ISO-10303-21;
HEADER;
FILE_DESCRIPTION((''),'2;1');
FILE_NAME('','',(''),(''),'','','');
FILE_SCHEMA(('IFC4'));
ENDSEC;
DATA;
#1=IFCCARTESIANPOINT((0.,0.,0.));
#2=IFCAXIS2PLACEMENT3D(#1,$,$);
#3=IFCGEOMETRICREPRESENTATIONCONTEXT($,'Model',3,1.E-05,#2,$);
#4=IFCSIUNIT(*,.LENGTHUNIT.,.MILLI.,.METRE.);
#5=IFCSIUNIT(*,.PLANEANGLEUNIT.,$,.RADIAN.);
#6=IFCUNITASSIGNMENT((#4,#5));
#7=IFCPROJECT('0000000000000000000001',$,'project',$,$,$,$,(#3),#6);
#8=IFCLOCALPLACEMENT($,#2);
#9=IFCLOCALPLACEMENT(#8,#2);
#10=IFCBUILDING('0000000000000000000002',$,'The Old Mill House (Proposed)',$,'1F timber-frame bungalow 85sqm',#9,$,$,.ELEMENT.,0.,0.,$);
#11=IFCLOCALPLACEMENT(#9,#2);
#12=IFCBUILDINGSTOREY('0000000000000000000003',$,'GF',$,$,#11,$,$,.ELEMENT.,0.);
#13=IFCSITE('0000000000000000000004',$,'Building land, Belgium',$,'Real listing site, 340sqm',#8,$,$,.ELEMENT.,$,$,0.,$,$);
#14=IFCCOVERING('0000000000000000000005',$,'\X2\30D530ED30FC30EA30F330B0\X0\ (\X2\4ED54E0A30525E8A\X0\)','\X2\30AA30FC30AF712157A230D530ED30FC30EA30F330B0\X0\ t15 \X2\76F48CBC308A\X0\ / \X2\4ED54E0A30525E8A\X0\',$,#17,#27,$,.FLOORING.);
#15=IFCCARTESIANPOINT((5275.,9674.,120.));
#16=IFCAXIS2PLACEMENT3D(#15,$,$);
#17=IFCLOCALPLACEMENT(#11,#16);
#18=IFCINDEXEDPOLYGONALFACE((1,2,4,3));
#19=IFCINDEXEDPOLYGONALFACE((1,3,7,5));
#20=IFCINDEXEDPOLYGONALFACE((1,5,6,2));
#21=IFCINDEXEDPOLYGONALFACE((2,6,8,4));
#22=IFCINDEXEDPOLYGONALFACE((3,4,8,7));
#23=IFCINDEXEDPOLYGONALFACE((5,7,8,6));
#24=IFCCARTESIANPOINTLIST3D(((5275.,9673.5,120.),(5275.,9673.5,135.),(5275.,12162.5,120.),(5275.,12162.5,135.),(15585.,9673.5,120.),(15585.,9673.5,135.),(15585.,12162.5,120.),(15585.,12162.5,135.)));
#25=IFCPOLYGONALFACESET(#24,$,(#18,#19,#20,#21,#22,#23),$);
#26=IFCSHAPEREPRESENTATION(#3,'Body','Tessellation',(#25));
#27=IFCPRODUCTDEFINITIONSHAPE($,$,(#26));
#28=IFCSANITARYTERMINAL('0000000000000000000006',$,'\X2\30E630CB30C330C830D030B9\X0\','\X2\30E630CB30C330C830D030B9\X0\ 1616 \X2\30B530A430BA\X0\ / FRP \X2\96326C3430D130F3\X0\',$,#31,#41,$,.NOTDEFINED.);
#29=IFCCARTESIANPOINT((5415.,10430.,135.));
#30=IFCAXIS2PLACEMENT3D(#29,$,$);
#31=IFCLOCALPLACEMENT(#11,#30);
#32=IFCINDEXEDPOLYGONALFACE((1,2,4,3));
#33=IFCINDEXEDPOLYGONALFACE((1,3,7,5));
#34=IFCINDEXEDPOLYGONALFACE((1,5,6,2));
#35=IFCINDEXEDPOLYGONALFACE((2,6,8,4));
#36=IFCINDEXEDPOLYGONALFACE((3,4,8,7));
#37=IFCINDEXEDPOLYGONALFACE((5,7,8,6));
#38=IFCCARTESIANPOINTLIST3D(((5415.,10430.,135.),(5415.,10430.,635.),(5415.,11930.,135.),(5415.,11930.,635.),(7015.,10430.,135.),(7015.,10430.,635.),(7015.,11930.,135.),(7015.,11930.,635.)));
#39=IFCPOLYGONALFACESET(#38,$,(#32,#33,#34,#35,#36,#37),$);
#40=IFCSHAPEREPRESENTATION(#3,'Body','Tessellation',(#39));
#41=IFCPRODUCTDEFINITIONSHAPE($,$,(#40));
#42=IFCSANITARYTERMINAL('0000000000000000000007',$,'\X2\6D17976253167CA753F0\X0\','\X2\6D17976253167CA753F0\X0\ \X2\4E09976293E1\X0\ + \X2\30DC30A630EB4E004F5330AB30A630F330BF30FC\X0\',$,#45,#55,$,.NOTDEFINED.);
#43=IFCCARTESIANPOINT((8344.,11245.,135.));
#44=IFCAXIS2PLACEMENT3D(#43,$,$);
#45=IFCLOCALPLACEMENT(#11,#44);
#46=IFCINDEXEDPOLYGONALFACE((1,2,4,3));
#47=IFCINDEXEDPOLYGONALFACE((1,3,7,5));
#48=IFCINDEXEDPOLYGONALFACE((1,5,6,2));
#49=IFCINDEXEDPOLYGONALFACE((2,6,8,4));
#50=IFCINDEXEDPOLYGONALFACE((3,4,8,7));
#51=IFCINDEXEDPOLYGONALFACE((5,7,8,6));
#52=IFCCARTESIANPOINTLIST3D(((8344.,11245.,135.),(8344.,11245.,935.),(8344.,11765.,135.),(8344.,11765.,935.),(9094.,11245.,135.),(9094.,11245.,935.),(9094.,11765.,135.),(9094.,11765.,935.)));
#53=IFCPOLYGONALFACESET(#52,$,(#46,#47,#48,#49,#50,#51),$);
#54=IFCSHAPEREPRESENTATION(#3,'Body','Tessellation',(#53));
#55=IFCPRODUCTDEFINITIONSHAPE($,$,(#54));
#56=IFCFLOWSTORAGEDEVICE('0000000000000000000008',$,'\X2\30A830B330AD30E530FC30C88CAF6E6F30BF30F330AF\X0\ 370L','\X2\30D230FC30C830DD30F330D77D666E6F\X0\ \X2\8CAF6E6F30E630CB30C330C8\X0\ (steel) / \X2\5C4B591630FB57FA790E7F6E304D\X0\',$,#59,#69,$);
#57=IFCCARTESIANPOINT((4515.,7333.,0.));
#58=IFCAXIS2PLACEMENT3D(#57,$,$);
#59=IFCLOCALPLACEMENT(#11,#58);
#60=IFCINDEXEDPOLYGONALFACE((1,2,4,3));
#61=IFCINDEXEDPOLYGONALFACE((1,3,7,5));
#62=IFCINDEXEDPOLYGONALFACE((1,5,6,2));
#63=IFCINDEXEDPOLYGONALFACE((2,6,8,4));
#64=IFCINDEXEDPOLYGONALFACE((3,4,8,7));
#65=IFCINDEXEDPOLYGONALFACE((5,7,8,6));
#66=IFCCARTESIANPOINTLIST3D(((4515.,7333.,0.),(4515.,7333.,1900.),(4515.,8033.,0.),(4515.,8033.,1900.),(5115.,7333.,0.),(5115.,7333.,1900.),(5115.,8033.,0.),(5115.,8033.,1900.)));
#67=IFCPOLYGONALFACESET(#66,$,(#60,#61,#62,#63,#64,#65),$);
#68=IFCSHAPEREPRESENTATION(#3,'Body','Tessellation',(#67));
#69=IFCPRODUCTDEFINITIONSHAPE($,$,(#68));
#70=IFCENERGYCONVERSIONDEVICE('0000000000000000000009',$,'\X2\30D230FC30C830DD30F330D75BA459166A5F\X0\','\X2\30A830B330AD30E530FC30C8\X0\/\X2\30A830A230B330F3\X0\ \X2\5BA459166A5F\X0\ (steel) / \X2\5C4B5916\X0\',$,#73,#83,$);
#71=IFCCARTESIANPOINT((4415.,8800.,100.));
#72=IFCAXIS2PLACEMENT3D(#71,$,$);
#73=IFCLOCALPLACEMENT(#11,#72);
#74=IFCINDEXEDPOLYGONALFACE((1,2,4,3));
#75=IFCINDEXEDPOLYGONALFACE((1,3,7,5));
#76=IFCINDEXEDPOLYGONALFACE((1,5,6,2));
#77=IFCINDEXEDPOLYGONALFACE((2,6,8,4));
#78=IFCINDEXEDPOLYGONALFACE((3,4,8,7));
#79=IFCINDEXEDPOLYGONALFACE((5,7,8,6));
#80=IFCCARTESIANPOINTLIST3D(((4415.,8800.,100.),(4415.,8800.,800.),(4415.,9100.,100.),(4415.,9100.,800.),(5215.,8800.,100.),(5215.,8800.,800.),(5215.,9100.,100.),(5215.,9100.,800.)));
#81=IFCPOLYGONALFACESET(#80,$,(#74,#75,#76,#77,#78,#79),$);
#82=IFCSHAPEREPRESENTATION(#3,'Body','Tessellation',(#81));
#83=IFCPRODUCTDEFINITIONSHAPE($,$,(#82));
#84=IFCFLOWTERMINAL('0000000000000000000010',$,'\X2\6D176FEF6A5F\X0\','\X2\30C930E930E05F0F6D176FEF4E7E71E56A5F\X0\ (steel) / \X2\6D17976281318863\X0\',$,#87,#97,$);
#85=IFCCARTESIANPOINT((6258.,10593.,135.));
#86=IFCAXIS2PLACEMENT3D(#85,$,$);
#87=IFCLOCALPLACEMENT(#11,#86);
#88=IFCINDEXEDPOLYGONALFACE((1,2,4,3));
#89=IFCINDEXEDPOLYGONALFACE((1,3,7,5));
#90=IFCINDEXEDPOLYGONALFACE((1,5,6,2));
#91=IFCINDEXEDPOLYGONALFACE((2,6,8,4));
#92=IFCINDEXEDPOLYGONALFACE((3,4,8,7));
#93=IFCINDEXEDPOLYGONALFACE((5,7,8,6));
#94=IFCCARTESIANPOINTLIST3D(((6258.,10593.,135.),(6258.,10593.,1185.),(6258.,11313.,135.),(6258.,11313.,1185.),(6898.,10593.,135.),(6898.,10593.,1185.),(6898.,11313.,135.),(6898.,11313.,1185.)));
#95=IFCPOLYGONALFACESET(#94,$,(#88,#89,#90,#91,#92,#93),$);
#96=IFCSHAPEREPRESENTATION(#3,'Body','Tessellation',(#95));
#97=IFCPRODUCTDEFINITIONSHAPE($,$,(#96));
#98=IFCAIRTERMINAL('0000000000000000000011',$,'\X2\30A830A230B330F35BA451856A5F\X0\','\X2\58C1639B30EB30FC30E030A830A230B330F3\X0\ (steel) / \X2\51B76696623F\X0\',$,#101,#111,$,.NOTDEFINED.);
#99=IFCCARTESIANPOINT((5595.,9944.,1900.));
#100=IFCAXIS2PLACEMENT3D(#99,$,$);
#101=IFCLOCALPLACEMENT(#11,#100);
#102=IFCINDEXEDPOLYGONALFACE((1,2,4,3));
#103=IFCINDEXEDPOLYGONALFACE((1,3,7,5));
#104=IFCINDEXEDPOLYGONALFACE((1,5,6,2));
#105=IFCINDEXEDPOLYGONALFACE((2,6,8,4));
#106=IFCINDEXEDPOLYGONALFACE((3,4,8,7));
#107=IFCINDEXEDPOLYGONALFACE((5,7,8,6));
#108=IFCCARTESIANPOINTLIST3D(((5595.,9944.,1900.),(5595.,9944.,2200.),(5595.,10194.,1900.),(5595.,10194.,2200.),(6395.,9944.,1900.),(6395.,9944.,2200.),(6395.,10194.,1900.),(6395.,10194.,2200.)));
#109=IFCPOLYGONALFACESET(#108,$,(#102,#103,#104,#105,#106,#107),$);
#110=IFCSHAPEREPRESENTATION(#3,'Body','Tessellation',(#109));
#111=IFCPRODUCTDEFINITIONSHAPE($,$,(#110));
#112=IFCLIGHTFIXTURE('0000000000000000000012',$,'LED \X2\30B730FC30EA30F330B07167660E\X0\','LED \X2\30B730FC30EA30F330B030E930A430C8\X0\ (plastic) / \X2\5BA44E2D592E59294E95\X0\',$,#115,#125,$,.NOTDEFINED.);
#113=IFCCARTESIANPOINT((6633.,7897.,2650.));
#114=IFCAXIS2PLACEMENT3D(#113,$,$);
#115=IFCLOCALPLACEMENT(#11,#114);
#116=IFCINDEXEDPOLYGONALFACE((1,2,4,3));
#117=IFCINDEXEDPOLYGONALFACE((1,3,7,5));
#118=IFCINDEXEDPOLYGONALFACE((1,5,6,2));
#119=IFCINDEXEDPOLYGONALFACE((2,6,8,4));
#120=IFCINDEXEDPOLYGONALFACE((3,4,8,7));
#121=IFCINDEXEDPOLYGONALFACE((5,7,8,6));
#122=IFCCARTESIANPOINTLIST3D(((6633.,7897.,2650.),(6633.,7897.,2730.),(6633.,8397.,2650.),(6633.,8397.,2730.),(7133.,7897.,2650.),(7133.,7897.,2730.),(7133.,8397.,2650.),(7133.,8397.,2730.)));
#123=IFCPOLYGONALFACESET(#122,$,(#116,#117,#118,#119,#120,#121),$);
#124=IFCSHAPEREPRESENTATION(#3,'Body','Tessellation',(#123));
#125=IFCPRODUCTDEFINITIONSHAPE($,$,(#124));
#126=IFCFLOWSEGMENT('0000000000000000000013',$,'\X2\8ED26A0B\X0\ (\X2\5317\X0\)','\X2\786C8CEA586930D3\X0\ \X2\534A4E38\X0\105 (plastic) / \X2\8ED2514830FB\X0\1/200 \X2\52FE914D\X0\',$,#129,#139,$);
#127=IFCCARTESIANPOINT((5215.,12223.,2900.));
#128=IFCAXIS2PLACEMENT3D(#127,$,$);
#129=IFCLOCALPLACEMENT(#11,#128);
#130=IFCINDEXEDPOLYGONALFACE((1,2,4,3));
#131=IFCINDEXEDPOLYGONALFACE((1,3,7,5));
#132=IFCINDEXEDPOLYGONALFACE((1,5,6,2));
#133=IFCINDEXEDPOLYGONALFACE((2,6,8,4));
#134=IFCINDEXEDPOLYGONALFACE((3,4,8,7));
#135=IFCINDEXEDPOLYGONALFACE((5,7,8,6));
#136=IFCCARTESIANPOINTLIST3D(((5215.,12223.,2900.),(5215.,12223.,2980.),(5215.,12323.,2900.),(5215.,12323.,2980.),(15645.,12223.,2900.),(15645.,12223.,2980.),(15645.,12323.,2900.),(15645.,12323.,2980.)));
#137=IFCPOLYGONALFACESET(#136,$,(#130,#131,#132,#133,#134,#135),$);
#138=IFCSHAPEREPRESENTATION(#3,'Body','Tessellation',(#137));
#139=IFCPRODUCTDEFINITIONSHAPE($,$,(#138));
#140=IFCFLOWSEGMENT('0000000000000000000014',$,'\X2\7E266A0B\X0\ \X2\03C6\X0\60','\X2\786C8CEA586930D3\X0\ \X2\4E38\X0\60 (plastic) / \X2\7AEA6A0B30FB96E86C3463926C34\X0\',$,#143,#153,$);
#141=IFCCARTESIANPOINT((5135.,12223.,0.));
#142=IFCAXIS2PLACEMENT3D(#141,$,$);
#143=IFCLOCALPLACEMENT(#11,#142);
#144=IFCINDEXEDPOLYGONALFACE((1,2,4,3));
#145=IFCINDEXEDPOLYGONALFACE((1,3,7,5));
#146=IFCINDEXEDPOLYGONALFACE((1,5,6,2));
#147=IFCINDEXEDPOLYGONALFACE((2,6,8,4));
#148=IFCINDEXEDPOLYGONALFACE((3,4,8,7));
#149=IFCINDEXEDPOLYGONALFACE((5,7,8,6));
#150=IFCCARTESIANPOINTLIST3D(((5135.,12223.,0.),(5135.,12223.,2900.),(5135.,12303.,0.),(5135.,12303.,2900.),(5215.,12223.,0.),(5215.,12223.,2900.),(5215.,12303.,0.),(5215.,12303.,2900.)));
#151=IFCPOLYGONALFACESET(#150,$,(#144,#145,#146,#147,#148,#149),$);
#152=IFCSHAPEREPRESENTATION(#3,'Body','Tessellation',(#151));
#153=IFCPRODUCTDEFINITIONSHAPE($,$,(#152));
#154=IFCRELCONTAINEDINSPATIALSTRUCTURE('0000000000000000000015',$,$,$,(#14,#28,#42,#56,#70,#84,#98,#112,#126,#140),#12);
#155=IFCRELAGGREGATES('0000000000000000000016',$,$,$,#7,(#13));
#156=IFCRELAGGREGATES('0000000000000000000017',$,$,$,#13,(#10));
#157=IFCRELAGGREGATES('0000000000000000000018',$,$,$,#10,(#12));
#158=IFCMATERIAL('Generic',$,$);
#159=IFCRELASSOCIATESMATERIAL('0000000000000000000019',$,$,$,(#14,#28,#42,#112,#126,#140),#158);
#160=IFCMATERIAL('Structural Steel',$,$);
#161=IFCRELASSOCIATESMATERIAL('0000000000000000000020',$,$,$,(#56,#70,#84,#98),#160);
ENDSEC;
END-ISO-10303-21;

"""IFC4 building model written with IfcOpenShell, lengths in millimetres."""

from ifc_helpers import new_model, si_unit, frame, frame_2d, origin, place, context, project, spatial, rectangle, extrude, material, element, save


model = new_model("IFC4")

# Units and contexts
model_context = context("Model", 3, precision=1e-05, world=origin())
ifc_project = project(units=[si_unit("LENGTHUNIT", "METRE", prefix="MILLI"), si_unit("PLANEANGLEUNIT", "RADIAN")], contexts=[model_context])

# Site, building, storey
site_placement = place(None, origin())
site = spatial("IfcSite", under=ifc_project, at=site_placement, Name="Building land, Belgium", ObjectType="Real listing site, 340sqm", CompositionType="ELEMENT", RefElevation=0.0)
building_placement = place(site_placement, origin())
building = spatial("IfcBuilding", under=site, at=building_placement, Name="The Old Mill House (Proposed)", ObjectType="1F timber-frame bungalow 85sqm", CompositionType="ELEMENT", ElevationOfRefHeight=0.0, ElevationOfTerrain=0.0)
storey_placement = place(building_placement, origin())
storey = spatial("IfcBuildingStorey", under=building, at=storey_placement, Name="GF", CompositionType="ELEMENT", Elevation=0.0)

# Shared definitions
ifc_material_1 = material(Name="Structural Steel")

# Covering
ifc_material_2 = material(Name="Generic")
covering_1_placement = place(storey_placement, frame((5275.0, 9674.0, 120.0)))
element("IfcCovering", 1, at=covering_1_placement, inside=storey, material=ifc_material_2, Name="フローリング (仕上げ床)", Description="オーク無垢フローリング t15 直貼り / 仕上げ床", PredefinedType="FLOORING", context=model_context, shape_type="SweptSolid", body=[
    extrude(rectangle(XDim=10310.0, YDim=2489.0, at=frame_2d((5155.0, 1244.0))), frame((5275.0, 9674.0, 120.0)), (0.0, 0.0, 1.0), 15.0),
])

# Sanitary terminals
sanitary_terminal_1_placement = place(storey_placement, frame((5415.0, 10430.0, 135.0)))
element("IfcSanitaryTerminal", 2, at=sanitary_terminal_1_placement, inside=storey, material=ifc_material_2, Name="ユニットバス", Description="ユニットバス 1616 サイズ / FRP 防水パン", PredefinedType="NOTDEFINED", context=model_context, shape_type="SweptSolid", body=[
    extrude(rectangle(XDim=1600.0, YDim=1500.0, at=frame_2d((800.0, 750.0))), frame((5415.0, 10430.0, 135.0)), (0.0, 0.0, 1.0), 500.0),
])
sanitary_terminal_2_placement = place(storey_placement, frame((8344.0, 11245.0, 135.0)))
element("IfcSanitaryTerminal", 3, at=sanitary_terminal_2_placement, inside=storey, material=ifc_material_2, Name="洗面化粧台", Description="洗面化粧台 三面鏡 + ボウル一体カウンター", PredefinedType="NOTDEFINED", context=model_context, shape_type="SweptSolid", body=[
    extrude(rectangle(XDim=750.0, YDim=520.0, at=frame_2d((375.0, 260.0))), frame((8344.0, 11245.0, 135.0)), (0.0, 0.0, 1.0), 800.0),
])

# Flow storage device
flow_storage_device_placement = place(storey_placement, frame((4515.0, 7333.0, 0.0)))
element("IfcFlowStorageDevice", 4, at=flow_storage_device_placement, inside=storey, material=ifc_material_1, Name="エコキュート貯湯タンク 370L", Description="ヒートポンプ給湯 貯湯ユニット (steel) / 屋外・基礎置き", context=model_context, shape_type="SweptSolid", body=[
    extrude(rectangle(XDim=600.0, YDim=700.0, at=frame_2d((300.0, 350.0))), frame((4515.0, 7333.0, 0.0)), (0.0, 0.0, 1.0), 1900.0),
])

# Energy conversion device
energy_conversion_device_placement = place(storey_placement, frame((4415.0, 8800.0, 100.0)))
element("IfcEnergyConversionDevice", 5, at=energy_conversion_device_placement, inside=storey, material=ifc_material_1, Name="ヒートポンプ室外機", Description="エコキュート/エアコン 室外機 (steel) / 屋外", context=model_context, shape_type="SweptSolid", body=[
    extrude(rectangle(XDim=800.0, YDim=300.0, at=frame_2d((400.0, 150.0))), frame((4415.0, 8800.0, 100.0)), (0.0, 0.0, 1.0), 700.0),
])

# Flow terminal
flow_terminal_placement = place(storey_placement, frame((6258.0, 10593.0, 135.0)))
element("IfcFlowTerminal", 6, at=flow_terminal_placement, inside=storey, material=ifc_material_1, Name="洗濯機", Description="ドラム式洗濯乾燥機 (steel) / 洗面脱衣", context=model_context, shape_type="SweptSolid", body=[
    extrude(rectangle(XDim=640.0, YDim=720.0, at=frame_2d((320.0, 360.0))), frame((6258.0, 10593.0, 135.0)), (0.0, 0.0, 1.0), 1050.0),
])

# Air terminal
air_terminal_placement = place(storey_placement, frame((5595.0, 9944.0, 1900.0)))
element("IfcAirTerminal", 7, at=air_terminal_placement, inside=storey, material=ifc_material_1, Name="エアコン室内機", Description="壁掛ルームエアコン (steel) / 冷暖房", PredefinedType="NOTDEFINED", context=model_context, shape_type="SweptSolid", body=[
    extrude(rectangle(XDim=800.0, YDim=250.0, at=frame_2d((400.0, 125.0))), frame((5595.0, 9944.0, 1900.0)), (0.0, 0.0, 1.0), 300.0),
])

# Light fixture
light_fixture_placement = place(storey_placement, frame((6633.0, 7897.0, 2650.0)))
element("IfcLightFixture", 8, at=light_fixture_placement, inside=storey, material=ifc_material_2, Name="LED シーリング照明", Description="LED シーリングライト (plastic) / 室中央天井", PredefinedType="NOTDEFINED", context=model_context, shape_type="SweptSolid", body=[
    extrude(rectangle(XDim=500.0, YDim=500.0, at=frame_2d((250.0, 250.0))), frame((6633.0, 7897.0, 2650.0)), (0.0, 0.0, 1.0), 80.0),
])

# Flow segments
flow_segment_1_placement = place(storey_placement, frame((5215.0, 12223.0, 2900.0)))
element("IfcFlowSegment", 9, at=flow_segment_1_placement, inside=storey, material=ifc_material_2, Name="軒樋 (北)", Description="硬質塩ビ 半丸105 (plastic) / 軒先・1/200 勾配", context=model_context, shape_type="SweptSolid", body=[
    extrude(rectangle(XDim=10430.0, YDim=100.0, at=frame_2d((5215.0, 50.0))), frame((5215.0, 12223.0, 2900.0)), (0.0, 0.0, 1.0), 80.0),
])
flow_segment_2_placement = place(storey_placement, frame((5135.0, 12223.0, 0.0)))
element("IfcFlowSegment", 10, at=flow_segment_2_placement, inside=storey, material=ifc_material_2, Name="縦樋 φ60", Description="硬質塩ビ 丸60 (plastic) / 竪樋・雨水排水", context=model_context, shape_type="SweptSolid", body=[
    extrude(rectangle(XDim=80.0, YDim=80.0, at=frame_2d((40.0, 40.0))), frame((5135.0, 12223.0, 0.0)), (0.0, 0.0, 1.0), 2900.0),
])

save(model, "model.ifc")
